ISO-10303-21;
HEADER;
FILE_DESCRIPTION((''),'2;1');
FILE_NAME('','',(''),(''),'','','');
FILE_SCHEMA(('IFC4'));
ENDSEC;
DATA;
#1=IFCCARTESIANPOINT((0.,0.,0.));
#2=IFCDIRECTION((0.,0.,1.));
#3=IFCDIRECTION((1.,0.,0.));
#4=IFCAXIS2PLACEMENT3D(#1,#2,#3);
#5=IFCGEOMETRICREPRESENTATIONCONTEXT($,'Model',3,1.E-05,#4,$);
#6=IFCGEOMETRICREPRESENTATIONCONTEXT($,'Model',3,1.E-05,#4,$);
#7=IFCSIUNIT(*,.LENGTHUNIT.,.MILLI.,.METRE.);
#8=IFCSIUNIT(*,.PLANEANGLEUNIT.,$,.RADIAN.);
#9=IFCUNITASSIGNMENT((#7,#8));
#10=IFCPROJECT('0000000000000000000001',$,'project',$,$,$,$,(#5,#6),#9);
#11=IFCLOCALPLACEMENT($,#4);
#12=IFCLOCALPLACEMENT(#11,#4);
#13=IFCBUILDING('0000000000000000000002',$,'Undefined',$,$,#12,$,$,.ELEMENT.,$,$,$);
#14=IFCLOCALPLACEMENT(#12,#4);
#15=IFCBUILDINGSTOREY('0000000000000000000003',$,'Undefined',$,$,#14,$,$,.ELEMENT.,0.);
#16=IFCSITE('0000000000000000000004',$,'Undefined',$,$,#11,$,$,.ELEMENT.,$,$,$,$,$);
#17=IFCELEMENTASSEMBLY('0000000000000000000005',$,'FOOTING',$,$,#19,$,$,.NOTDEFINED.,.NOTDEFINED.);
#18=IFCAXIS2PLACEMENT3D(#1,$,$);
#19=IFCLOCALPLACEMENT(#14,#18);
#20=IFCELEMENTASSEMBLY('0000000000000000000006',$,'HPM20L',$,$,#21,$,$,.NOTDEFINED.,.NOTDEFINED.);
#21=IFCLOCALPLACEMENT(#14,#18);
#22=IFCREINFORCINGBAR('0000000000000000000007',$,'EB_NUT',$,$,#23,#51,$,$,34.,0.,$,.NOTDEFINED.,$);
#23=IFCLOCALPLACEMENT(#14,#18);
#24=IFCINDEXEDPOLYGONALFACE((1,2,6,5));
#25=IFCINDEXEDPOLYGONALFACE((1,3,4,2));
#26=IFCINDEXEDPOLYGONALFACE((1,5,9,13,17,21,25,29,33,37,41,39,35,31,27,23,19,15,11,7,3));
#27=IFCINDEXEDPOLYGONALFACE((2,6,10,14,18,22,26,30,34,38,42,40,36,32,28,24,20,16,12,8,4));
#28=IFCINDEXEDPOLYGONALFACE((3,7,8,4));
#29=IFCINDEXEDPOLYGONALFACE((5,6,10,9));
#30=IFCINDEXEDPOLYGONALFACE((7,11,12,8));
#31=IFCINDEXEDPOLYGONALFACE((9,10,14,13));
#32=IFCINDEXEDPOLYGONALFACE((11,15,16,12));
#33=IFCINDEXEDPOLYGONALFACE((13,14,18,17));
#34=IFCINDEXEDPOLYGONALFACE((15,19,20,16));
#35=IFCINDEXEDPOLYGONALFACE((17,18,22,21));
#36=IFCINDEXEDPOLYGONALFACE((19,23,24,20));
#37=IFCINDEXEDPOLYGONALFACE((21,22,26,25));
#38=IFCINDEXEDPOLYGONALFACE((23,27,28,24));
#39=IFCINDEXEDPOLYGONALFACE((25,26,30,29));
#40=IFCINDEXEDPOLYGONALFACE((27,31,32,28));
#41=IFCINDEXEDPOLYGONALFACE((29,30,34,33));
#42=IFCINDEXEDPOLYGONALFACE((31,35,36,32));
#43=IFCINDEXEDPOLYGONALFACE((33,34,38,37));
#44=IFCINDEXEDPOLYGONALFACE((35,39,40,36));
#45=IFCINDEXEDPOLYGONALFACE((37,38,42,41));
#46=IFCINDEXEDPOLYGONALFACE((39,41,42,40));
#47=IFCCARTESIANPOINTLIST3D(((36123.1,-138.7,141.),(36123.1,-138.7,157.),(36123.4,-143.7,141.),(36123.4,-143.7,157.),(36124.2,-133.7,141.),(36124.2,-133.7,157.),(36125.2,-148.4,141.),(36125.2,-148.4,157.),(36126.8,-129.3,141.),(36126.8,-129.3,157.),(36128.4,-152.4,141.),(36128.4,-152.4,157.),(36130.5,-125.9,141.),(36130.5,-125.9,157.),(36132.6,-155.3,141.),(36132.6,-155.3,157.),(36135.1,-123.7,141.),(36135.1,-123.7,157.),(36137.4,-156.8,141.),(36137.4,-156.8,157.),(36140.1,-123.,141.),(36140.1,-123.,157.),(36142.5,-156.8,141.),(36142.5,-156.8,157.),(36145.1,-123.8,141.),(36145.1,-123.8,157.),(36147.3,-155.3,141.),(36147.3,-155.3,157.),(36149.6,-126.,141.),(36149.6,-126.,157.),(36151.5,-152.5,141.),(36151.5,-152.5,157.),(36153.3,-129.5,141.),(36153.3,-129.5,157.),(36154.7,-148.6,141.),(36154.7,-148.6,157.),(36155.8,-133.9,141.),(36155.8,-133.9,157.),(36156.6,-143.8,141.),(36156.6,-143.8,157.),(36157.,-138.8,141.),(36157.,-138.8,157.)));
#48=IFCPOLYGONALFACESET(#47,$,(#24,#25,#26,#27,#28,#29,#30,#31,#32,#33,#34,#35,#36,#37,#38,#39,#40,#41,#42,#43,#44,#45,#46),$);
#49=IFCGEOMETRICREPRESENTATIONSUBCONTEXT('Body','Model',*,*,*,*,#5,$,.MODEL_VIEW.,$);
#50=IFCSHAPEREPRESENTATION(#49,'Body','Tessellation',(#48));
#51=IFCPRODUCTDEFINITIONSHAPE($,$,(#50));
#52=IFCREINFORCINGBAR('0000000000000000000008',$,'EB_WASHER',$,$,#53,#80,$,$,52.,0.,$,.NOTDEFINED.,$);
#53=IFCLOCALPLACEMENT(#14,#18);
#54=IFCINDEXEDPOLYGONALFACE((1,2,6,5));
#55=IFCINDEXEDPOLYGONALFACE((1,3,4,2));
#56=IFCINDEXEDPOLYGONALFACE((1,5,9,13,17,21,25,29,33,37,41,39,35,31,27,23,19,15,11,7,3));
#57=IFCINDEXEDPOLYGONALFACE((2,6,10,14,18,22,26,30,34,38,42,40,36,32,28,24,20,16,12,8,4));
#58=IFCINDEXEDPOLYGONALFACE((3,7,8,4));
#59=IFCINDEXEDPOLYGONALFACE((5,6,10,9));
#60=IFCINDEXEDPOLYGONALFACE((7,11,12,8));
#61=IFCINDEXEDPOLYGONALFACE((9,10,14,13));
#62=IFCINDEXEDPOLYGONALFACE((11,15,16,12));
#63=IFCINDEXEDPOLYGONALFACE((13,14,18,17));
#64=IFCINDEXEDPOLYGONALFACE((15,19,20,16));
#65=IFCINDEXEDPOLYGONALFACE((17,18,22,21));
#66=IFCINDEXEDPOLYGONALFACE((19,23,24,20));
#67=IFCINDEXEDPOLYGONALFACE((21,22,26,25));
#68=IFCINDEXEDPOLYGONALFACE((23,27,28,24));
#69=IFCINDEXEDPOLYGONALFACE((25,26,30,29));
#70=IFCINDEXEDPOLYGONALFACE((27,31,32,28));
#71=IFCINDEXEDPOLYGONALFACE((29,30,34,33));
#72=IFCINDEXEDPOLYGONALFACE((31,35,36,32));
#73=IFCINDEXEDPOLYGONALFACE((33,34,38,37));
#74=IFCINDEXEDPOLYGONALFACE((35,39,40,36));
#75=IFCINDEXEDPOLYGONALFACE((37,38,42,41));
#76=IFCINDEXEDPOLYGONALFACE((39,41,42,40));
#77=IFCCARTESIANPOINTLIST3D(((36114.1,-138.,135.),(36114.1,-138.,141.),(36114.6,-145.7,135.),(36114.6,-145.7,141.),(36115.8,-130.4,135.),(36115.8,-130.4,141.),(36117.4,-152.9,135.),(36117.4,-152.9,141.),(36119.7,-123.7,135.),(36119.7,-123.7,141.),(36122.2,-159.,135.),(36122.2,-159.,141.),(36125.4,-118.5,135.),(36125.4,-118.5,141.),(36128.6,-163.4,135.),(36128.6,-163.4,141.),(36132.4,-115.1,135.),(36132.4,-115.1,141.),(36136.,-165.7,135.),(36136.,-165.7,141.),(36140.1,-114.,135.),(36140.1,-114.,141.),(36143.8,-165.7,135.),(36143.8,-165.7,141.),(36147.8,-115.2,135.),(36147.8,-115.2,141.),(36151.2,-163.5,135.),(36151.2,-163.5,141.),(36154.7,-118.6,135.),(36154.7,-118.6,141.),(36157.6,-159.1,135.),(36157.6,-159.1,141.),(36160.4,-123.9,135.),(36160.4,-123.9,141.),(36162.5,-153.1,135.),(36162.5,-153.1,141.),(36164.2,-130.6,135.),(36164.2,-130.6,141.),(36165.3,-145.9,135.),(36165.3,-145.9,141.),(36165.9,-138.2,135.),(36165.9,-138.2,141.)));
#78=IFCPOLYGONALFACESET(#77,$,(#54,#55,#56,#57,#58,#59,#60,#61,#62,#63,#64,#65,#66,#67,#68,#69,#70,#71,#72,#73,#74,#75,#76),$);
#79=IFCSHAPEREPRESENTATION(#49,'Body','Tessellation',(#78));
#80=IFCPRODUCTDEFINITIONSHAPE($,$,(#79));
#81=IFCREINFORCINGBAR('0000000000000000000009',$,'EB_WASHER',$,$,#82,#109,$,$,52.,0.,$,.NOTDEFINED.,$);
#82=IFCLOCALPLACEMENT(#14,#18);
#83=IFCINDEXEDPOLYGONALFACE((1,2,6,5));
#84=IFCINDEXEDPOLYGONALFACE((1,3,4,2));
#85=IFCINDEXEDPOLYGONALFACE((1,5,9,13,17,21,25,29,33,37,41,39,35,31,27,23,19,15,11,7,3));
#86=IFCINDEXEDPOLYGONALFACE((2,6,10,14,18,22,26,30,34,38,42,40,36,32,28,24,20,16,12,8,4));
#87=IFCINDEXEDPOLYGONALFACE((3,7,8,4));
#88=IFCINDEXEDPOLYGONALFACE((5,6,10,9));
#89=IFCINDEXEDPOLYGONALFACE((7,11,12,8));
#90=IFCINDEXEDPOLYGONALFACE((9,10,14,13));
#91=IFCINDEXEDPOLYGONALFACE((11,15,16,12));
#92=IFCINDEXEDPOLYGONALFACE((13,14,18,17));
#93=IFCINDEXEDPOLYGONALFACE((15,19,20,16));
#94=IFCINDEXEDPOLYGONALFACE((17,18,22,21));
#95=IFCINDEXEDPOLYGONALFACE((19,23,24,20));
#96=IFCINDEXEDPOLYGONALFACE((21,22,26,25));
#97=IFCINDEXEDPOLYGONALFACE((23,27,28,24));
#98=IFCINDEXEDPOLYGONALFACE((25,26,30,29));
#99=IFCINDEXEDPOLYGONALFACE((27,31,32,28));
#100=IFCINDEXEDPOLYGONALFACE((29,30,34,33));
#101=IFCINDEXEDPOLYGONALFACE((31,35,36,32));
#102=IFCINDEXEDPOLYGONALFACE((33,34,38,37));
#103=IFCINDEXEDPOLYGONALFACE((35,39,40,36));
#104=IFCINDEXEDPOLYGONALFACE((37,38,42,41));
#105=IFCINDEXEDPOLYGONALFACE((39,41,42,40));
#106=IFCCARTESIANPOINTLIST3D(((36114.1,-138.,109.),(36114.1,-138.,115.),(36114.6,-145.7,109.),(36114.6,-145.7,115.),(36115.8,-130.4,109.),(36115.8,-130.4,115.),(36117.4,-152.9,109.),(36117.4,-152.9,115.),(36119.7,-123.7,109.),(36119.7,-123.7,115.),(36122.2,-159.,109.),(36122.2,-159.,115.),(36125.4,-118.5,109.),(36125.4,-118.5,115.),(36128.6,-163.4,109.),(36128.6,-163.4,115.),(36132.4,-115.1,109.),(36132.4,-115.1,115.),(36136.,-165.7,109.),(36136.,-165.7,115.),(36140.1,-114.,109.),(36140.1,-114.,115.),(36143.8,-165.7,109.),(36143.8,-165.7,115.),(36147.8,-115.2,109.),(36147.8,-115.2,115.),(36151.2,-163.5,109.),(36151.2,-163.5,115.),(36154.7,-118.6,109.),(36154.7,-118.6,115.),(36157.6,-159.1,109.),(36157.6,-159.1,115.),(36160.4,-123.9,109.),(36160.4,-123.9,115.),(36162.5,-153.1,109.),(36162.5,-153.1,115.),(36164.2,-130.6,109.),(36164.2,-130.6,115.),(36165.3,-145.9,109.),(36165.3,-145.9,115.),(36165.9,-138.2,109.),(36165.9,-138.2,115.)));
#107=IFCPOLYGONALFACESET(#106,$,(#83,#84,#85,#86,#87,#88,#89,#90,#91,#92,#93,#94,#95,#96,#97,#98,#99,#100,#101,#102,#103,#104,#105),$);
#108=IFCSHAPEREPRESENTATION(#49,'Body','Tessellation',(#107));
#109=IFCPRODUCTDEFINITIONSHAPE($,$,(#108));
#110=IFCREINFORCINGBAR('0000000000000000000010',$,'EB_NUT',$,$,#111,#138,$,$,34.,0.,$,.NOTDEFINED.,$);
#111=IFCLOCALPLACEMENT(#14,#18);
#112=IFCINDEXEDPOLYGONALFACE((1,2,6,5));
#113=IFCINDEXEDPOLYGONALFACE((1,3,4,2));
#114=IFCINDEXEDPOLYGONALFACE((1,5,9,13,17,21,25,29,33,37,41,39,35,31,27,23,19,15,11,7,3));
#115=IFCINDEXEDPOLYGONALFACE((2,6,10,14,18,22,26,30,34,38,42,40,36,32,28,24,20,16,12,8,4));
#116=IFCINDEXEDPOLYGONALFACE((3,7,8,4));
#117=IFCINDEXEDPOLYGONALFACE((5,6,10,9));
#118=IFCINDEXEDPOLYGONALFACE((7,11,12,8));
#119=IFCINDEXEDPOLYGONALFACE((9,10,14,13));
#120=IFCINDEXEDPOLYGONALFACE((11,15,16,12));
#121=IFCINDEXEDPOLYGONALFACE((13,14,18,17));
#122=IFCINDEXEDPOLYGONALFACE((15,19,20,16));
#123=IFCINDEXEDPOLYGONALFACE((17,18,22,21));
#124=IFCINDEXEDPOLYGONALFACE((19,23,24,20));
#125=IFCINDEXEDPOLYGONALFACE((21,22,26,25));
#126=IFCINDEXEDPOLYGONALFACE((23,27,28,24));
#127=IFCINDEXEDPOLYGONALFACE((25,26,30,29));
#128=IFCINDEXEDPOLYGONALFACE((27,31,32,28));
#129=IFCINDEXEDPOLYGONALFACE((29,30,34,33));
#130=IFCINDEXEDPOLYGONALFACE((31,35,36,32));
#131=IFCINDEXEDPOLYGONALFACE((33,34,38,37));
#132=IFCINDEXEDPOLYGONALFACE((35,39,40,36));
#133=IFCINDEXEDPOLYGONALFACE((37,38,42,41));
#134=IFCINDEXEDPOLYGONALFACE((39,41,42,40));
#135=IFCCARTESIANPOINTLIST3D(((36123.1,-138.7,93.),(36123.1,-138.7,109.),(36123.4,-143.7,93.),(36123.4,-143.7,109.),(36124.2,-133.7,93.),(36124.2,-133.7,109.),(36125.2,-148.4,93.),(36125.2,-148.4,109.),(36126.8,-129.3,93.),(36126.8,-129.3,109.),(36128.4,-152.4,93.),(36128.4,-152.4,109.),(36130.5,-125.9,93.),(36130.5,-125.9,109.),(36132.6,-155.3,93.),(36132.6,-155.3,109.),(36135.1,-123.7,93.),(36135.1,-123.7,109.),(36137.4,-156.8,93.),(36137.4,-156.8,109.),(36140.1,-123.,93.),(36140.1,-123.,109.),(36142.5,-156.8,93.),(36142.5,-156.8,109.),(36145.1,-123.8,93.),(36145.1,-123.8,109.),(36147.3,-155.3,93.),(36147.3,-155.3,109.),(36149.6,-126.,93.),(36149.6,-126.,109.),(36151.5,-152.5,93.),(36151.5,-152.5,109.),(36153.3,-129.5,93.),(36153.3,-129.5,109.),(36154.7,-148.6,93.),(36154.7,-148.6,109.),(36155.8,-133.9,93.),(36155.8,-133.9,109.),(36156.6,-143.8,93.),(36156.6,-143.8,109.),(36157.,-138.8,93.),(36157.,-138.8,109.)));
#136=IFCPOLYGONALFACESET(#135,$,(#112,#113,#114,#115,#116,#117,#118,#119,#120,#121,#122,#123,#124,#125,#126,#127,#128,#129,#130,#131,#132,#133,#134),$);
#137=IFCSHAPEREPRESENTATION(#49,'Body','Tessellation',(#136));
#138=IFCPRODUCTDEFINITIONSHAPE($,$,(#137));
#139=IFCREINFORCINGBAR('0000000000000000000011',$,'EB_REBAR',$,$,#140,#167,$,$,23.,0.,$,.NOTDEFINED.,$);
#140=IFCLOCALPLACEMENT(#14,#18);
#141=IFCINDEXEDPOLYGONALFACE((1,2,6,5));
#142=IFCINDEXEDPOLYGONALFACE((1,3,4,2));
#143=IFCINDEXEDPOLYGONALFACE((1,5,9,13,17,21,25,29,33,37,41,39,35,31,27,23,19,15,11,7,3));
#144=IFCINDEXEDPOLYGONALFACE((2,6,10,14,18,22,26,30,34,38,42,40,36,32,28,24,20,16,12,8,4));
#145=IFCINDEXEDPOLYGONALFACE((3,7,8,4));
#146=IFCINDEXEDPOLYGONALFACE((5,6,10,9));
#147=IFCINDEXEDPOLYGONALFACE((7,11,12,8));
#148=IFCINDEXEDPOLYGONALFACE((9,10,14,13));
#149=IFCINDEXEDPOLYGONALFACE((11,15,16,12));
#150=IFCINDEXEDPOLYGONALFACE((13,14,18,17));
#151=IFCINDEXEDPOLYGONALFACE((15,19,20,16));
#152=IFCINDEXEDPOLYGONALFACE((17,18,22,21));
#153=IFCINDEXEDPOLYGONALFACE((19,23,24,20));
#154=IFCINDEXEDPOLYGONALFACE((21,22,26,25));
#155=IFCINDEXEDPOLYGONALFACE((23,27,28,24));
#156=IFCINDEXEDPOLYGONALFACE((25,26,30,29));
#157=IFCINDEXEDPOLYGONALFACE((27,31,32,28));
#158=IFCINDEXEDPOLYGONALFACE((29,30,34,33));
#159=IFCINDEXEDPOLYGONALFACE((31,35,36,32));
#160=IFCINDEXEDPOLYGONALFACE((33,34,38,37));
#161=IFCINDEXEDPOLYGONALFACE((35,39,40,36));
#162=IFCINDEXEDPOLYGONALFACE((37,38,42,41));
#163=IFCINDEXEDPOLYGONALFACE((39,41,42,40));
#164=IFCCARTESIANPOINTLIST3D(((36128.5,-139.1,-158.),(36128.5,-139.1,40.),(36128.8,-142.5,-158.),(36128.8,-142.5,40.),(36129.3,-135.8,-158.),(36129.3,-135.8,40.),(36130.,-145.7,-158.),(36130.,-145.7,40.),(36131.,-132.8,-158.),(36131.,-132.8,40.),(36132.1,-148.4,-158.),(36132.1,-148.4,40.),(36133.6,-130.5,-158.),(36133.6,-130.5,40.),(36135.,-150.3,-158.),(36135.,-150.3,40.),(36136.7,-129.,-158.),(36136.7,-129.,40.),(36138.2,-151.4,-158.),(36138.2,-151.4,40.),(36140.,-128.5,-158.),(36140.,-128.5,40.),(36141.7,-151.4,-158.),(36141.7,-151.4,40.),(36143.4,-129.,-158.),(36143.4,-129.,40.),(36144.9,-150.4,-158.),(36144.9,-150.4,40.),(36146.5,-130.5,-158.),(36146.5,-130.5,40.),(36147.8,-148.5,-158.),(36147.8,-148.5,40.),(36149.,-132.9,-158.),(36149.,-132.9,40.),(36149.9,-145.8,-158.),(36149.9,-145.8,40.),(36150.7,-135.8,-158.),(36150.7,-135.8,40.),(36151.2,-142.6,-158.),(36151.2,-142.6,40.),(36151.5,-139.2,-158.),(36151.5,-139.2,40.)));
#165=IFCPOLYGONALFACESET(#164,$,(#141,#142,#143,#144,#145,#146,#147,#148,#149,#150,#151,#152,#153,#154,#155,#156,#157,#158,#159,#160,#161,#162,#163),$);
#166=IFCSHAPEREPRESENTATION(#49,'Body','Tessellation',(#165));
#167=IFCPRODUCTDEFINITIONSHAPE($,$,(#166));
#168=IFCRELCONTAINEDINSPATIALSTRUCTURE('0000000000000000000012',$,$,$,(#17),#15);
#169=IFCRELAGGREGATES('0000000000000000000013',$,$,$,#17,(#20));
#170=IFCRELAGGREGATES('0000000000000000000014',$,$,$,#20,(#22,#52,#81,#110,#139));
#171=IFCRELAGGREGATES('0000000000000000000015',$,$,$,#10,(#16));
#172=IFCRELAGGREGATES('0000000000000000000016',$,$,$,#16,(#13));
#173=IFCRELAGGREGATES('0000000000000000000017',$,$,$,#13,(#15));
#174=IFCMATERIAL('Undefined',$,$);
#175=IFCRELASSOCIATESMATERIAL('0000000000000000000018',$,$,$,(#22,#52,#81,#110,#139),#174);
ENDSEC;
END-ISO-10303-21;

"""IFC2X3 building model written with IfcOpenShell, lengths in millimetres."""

from ifc_helpers import new_model, entity, si_unit, frame, origin_with_axes, place, context, subcontext, project, spatial, source, transform, mapped, material, element, aggregate, save


model = new_model("IFC2X3")

# Units and contexts
model_context_1 = context("Model", 3, precision=1e-05, world=origin_with_axes())
model_context_2 = context("Model", 3, precision=1e-05, world=origin_with_axes())
body_context = subcontext(model_context_1, "Body", "Model", "MODEL_VIEW")
ifc_project = project(units=[si_unit("LENGTHUNIT", "METRE", prefix="MILLI"), si_unit("PLANEANGLEUNIT", "RADIAN")], contexts=[model_context_1, model_context_2])

# Site, building, storey
site_placement = place(None, origin_with_axes())
site = spatial("IfcSite", under=ifc_project, at=site_placement, Name="Undefined", CompositionType="ELEMENT")
building_placement = place(site_placement, origin_with_axes())
building = spatial("IfcBuilding", under=site, at=building_placement, Name="Undefined", CompositionType="ELEMENT")
storey_placement = place(building_placement, origin_with_axes())
storey = spatial("IfcBuildingStorey", under=building, at=storey_placement, Name="Undefined", CompositionType="ELEMENT", Elevation=0.0)

# Element assembly
assembly_1_placement = place(storey_placement, origin_with_axes())
assembly_1 = element("IfcElementAssembly", 1, at=assembly_1_placement, inside=storey, Name="FOOTING", AssemblyPlace="NOTDEFINED", PredefinedType="NOTDEFINED")

# Shared definitions
ifc_material_1 = material(Name="Undefined")

# Element assembly
assembly_2_placement = place(assembly_1_placement, origin_with_axes())
assembly_2 = element("IfcElementAssembly", 2, at=assembly_2_placement, Name="HPM20L", AssemblyPlace="NOTDEFINED", PredefinedType="NOTDEFINED")
aggregate(assembly_1, [assembly_2])

# Reinforcing bars
shared_shape_1 = source(origin_with_axes(), body_context, "Body", "AdvancedSweptSolid", [
    entity("IfcSweptDiskSolid", entity("IfcTrimmedCurve", entity("IfcLine", entity("IfcCartesianPoint", [0.0, 0.0, 0.0]), entity("IfcVector", entity("IfcDirection", [1.0, 0.0, 0.0]), 1.0)), [entity("IfcParameterValue", 0.0)], [entity("IfcParameterValue", 16.0)], True, "PARAMETER"), 17.0, None, 0.0, 16.0),
])
reinforcing_bar_1_placement = place(assembly_2_placement, frame((36140.0, -140.0, 157.0), z_axis=(0.003874, 0.999992, 0.0), x_axis=(0.0, 0.0, -1.0)))
reinforcing_bar_1 = element("IfcReinforcingBar", 3, at=reinforcing_bar_1_placement, material=ifc_material_1, Name="EB_NUT", BarRole="NOTDEFINED", CrossSectionArea=0.0, NominalDiameter=34.0, context=body_context, shape_type="MappedRepresentation", body=[
    mapped(shared_shape_1, transform((0.0, 0.0, 0.0))),
])
shared_shape_2 = source(origin_with_axes(), body_context, "Body", "AdvancedSweptSolid", [
    entity("IfcSweptDiskSolid", entity("IfcTrimmedCurve", entity("IfcLine", entity("IfcCartesianPoint", [0.0, 0.0, 0.0]), entity("IfcVector", entity("IfcDirection", [1.0, 0.0, 0.0]), 1.0)), [entity("IfcParameterValue", 0.0)], [entity("IfcParameterValue", 6.0)], True, "PARAMETER"), 26.0, None, 0.0, 6.0),
])
reinforcing_bar_2_placement = place(assembly_2_placement, frame((36140.0, -140.0, 141.0), z_axis=(0.003874, 0.999992, 0.0), x_axis=(0.0, 0.0, -1.0)))
reinforcing_bar_2 = element("IfcReinforcingBar", 4, at=reinforcing_bar_2_placement, material=ifc_material_1, Name="EB_WASHER", BarRole="NOTDEFINED", CrossSectionArea=0.0, NominalDiameter=52.0, context=body_context, shape_type="MappedRepresentation", body=[
    mapped(shared_shape_2, transform((0.0, 0.0, 0.0))),
])
shared_shape_3 = source(origin_with_axes(), body_context, "Body", "AdvancedSweptSolid", [
    entity("IfcSweptDiskSolid", entity("IfcTrimmedCurve", entity("IfcLine", entity("IfcCartesianPoint", [0.0, 0.0, 0.0]), entity("IfcVector", entity("IfcDirection", [1.0, 0.0, 0.0]), 1.0)), [entity("IfcParameterValue", 0.0)], [entity("IfcParameterValue", 6.0)], True, "PARAMETER"), 26.0, None, 0.0, 6.0),
])
reinforcing_bar_3_placement = place(assembly_2_placement, frame((36140.0, -140.0, 115.0), z_axis=(0.003874, 0.999992, 0.0), x_axis=(0.0, 0.0, -1.0)))
reinforcing_bar_3 = element("IfcReinforcingBar", 5, at=reinforcing_bar_3_placement, material=ifc_material_1, Name="EB_WASHER", BarRole="NOTDEFINED", CrossSectionArea=0.0, NominalDiameter=52.0, context=body_context, shape_type="MappedRepresentation", body=[
    mapped(shared_shape_3, transform((0.0, 0.0, 0.0))),
])
shared_shape_4 = source(origin_with_axes(), body_context, "Body", "AdvancedSweptSolid", [
    entity("IfcSweptDiskSolid", entity("IfcTrimmedCurve", entity("IfcLine", entity("IfcCartesianPoint", [0.0, 0.0, 0.0]), entity("IfcVector", entity("IfcDirection", [1.0, 0.0, 0.0]), 1.0)), [entity("IfcParameterValue", 0.0)], [entity("IfcParameterValue", 16.0)], True, "PARAMETER"), 17.0, None, 0.0, 16.0),
])
reinforcing_bar_4_placement = place(assembly_2_placement, frame((36140.0, -140.0, 109.0), z_axis=(0.003874, 0.999992, 0.0), x_axis=(0.0, 0.0, -1.0)))
reinforcing_bar_4 = element("IfcReinforcingBar", 6, at=reinforcing_bar_4_placement, material=ifc_material_1, Name="EB_NUT", BarRole="NOTDEFINED", CrossSectionArea=0.0, NominalDiameter=34.0, context=body_context, shape_type="MappedRepresentation", body=[
    mapped(shared_shape_4, transform((0.0, 0.0, 0.0))),
])
shared_shape_5 = source(origin_with_axes(), body_context, "Body", "AdvancedSweptSolid", [
    entity("IfcSweptDiskSolid", entity("IfcTrimmedCurve", entity("IfcLine", entity("IfcCartesianPoint", [0.0, 0.0, 0.0]), entity("IfcVector", entity("IfcDirection", [1.0, 0.0, 0.0]), 1.0)), [entity("IfcParameterValue", 0.0)], [entity("IfcParameterValue", 198.0)], True, "PARAMETER"), 11.5, None, 0.0, 198.0),
])
reinforcing_bar_5_placement = place(assembly_2_placement, frame((36140.0, -140.0, 40.0), z_axis=(0.003874, 0.999992, 0.0), x_axis=(0.0, 0.0, -1.0)))
reinforcing_bar_5 = element("IfcReinforcingBar", 7, at=reinforcing_bar_5_placement, material=ifc_material_1, Name="EB_REBAR", BarRole="NOTDEFINED", CrossSectionArea=0.0, NominalDiameter=23.0, context=body_context, shape_type="MappedRepresentation", body=[
    mapped(shared_shape_5, transform((0.0, 0.0, 0.0))),
])
aggregate(assembly_2, [reinforcing_bar_1, reinforcing_bar_2, reinforcing_bar_3, reinforcing_bar_4, reinforcing_bar_5])

save(model, "model.ifc")
